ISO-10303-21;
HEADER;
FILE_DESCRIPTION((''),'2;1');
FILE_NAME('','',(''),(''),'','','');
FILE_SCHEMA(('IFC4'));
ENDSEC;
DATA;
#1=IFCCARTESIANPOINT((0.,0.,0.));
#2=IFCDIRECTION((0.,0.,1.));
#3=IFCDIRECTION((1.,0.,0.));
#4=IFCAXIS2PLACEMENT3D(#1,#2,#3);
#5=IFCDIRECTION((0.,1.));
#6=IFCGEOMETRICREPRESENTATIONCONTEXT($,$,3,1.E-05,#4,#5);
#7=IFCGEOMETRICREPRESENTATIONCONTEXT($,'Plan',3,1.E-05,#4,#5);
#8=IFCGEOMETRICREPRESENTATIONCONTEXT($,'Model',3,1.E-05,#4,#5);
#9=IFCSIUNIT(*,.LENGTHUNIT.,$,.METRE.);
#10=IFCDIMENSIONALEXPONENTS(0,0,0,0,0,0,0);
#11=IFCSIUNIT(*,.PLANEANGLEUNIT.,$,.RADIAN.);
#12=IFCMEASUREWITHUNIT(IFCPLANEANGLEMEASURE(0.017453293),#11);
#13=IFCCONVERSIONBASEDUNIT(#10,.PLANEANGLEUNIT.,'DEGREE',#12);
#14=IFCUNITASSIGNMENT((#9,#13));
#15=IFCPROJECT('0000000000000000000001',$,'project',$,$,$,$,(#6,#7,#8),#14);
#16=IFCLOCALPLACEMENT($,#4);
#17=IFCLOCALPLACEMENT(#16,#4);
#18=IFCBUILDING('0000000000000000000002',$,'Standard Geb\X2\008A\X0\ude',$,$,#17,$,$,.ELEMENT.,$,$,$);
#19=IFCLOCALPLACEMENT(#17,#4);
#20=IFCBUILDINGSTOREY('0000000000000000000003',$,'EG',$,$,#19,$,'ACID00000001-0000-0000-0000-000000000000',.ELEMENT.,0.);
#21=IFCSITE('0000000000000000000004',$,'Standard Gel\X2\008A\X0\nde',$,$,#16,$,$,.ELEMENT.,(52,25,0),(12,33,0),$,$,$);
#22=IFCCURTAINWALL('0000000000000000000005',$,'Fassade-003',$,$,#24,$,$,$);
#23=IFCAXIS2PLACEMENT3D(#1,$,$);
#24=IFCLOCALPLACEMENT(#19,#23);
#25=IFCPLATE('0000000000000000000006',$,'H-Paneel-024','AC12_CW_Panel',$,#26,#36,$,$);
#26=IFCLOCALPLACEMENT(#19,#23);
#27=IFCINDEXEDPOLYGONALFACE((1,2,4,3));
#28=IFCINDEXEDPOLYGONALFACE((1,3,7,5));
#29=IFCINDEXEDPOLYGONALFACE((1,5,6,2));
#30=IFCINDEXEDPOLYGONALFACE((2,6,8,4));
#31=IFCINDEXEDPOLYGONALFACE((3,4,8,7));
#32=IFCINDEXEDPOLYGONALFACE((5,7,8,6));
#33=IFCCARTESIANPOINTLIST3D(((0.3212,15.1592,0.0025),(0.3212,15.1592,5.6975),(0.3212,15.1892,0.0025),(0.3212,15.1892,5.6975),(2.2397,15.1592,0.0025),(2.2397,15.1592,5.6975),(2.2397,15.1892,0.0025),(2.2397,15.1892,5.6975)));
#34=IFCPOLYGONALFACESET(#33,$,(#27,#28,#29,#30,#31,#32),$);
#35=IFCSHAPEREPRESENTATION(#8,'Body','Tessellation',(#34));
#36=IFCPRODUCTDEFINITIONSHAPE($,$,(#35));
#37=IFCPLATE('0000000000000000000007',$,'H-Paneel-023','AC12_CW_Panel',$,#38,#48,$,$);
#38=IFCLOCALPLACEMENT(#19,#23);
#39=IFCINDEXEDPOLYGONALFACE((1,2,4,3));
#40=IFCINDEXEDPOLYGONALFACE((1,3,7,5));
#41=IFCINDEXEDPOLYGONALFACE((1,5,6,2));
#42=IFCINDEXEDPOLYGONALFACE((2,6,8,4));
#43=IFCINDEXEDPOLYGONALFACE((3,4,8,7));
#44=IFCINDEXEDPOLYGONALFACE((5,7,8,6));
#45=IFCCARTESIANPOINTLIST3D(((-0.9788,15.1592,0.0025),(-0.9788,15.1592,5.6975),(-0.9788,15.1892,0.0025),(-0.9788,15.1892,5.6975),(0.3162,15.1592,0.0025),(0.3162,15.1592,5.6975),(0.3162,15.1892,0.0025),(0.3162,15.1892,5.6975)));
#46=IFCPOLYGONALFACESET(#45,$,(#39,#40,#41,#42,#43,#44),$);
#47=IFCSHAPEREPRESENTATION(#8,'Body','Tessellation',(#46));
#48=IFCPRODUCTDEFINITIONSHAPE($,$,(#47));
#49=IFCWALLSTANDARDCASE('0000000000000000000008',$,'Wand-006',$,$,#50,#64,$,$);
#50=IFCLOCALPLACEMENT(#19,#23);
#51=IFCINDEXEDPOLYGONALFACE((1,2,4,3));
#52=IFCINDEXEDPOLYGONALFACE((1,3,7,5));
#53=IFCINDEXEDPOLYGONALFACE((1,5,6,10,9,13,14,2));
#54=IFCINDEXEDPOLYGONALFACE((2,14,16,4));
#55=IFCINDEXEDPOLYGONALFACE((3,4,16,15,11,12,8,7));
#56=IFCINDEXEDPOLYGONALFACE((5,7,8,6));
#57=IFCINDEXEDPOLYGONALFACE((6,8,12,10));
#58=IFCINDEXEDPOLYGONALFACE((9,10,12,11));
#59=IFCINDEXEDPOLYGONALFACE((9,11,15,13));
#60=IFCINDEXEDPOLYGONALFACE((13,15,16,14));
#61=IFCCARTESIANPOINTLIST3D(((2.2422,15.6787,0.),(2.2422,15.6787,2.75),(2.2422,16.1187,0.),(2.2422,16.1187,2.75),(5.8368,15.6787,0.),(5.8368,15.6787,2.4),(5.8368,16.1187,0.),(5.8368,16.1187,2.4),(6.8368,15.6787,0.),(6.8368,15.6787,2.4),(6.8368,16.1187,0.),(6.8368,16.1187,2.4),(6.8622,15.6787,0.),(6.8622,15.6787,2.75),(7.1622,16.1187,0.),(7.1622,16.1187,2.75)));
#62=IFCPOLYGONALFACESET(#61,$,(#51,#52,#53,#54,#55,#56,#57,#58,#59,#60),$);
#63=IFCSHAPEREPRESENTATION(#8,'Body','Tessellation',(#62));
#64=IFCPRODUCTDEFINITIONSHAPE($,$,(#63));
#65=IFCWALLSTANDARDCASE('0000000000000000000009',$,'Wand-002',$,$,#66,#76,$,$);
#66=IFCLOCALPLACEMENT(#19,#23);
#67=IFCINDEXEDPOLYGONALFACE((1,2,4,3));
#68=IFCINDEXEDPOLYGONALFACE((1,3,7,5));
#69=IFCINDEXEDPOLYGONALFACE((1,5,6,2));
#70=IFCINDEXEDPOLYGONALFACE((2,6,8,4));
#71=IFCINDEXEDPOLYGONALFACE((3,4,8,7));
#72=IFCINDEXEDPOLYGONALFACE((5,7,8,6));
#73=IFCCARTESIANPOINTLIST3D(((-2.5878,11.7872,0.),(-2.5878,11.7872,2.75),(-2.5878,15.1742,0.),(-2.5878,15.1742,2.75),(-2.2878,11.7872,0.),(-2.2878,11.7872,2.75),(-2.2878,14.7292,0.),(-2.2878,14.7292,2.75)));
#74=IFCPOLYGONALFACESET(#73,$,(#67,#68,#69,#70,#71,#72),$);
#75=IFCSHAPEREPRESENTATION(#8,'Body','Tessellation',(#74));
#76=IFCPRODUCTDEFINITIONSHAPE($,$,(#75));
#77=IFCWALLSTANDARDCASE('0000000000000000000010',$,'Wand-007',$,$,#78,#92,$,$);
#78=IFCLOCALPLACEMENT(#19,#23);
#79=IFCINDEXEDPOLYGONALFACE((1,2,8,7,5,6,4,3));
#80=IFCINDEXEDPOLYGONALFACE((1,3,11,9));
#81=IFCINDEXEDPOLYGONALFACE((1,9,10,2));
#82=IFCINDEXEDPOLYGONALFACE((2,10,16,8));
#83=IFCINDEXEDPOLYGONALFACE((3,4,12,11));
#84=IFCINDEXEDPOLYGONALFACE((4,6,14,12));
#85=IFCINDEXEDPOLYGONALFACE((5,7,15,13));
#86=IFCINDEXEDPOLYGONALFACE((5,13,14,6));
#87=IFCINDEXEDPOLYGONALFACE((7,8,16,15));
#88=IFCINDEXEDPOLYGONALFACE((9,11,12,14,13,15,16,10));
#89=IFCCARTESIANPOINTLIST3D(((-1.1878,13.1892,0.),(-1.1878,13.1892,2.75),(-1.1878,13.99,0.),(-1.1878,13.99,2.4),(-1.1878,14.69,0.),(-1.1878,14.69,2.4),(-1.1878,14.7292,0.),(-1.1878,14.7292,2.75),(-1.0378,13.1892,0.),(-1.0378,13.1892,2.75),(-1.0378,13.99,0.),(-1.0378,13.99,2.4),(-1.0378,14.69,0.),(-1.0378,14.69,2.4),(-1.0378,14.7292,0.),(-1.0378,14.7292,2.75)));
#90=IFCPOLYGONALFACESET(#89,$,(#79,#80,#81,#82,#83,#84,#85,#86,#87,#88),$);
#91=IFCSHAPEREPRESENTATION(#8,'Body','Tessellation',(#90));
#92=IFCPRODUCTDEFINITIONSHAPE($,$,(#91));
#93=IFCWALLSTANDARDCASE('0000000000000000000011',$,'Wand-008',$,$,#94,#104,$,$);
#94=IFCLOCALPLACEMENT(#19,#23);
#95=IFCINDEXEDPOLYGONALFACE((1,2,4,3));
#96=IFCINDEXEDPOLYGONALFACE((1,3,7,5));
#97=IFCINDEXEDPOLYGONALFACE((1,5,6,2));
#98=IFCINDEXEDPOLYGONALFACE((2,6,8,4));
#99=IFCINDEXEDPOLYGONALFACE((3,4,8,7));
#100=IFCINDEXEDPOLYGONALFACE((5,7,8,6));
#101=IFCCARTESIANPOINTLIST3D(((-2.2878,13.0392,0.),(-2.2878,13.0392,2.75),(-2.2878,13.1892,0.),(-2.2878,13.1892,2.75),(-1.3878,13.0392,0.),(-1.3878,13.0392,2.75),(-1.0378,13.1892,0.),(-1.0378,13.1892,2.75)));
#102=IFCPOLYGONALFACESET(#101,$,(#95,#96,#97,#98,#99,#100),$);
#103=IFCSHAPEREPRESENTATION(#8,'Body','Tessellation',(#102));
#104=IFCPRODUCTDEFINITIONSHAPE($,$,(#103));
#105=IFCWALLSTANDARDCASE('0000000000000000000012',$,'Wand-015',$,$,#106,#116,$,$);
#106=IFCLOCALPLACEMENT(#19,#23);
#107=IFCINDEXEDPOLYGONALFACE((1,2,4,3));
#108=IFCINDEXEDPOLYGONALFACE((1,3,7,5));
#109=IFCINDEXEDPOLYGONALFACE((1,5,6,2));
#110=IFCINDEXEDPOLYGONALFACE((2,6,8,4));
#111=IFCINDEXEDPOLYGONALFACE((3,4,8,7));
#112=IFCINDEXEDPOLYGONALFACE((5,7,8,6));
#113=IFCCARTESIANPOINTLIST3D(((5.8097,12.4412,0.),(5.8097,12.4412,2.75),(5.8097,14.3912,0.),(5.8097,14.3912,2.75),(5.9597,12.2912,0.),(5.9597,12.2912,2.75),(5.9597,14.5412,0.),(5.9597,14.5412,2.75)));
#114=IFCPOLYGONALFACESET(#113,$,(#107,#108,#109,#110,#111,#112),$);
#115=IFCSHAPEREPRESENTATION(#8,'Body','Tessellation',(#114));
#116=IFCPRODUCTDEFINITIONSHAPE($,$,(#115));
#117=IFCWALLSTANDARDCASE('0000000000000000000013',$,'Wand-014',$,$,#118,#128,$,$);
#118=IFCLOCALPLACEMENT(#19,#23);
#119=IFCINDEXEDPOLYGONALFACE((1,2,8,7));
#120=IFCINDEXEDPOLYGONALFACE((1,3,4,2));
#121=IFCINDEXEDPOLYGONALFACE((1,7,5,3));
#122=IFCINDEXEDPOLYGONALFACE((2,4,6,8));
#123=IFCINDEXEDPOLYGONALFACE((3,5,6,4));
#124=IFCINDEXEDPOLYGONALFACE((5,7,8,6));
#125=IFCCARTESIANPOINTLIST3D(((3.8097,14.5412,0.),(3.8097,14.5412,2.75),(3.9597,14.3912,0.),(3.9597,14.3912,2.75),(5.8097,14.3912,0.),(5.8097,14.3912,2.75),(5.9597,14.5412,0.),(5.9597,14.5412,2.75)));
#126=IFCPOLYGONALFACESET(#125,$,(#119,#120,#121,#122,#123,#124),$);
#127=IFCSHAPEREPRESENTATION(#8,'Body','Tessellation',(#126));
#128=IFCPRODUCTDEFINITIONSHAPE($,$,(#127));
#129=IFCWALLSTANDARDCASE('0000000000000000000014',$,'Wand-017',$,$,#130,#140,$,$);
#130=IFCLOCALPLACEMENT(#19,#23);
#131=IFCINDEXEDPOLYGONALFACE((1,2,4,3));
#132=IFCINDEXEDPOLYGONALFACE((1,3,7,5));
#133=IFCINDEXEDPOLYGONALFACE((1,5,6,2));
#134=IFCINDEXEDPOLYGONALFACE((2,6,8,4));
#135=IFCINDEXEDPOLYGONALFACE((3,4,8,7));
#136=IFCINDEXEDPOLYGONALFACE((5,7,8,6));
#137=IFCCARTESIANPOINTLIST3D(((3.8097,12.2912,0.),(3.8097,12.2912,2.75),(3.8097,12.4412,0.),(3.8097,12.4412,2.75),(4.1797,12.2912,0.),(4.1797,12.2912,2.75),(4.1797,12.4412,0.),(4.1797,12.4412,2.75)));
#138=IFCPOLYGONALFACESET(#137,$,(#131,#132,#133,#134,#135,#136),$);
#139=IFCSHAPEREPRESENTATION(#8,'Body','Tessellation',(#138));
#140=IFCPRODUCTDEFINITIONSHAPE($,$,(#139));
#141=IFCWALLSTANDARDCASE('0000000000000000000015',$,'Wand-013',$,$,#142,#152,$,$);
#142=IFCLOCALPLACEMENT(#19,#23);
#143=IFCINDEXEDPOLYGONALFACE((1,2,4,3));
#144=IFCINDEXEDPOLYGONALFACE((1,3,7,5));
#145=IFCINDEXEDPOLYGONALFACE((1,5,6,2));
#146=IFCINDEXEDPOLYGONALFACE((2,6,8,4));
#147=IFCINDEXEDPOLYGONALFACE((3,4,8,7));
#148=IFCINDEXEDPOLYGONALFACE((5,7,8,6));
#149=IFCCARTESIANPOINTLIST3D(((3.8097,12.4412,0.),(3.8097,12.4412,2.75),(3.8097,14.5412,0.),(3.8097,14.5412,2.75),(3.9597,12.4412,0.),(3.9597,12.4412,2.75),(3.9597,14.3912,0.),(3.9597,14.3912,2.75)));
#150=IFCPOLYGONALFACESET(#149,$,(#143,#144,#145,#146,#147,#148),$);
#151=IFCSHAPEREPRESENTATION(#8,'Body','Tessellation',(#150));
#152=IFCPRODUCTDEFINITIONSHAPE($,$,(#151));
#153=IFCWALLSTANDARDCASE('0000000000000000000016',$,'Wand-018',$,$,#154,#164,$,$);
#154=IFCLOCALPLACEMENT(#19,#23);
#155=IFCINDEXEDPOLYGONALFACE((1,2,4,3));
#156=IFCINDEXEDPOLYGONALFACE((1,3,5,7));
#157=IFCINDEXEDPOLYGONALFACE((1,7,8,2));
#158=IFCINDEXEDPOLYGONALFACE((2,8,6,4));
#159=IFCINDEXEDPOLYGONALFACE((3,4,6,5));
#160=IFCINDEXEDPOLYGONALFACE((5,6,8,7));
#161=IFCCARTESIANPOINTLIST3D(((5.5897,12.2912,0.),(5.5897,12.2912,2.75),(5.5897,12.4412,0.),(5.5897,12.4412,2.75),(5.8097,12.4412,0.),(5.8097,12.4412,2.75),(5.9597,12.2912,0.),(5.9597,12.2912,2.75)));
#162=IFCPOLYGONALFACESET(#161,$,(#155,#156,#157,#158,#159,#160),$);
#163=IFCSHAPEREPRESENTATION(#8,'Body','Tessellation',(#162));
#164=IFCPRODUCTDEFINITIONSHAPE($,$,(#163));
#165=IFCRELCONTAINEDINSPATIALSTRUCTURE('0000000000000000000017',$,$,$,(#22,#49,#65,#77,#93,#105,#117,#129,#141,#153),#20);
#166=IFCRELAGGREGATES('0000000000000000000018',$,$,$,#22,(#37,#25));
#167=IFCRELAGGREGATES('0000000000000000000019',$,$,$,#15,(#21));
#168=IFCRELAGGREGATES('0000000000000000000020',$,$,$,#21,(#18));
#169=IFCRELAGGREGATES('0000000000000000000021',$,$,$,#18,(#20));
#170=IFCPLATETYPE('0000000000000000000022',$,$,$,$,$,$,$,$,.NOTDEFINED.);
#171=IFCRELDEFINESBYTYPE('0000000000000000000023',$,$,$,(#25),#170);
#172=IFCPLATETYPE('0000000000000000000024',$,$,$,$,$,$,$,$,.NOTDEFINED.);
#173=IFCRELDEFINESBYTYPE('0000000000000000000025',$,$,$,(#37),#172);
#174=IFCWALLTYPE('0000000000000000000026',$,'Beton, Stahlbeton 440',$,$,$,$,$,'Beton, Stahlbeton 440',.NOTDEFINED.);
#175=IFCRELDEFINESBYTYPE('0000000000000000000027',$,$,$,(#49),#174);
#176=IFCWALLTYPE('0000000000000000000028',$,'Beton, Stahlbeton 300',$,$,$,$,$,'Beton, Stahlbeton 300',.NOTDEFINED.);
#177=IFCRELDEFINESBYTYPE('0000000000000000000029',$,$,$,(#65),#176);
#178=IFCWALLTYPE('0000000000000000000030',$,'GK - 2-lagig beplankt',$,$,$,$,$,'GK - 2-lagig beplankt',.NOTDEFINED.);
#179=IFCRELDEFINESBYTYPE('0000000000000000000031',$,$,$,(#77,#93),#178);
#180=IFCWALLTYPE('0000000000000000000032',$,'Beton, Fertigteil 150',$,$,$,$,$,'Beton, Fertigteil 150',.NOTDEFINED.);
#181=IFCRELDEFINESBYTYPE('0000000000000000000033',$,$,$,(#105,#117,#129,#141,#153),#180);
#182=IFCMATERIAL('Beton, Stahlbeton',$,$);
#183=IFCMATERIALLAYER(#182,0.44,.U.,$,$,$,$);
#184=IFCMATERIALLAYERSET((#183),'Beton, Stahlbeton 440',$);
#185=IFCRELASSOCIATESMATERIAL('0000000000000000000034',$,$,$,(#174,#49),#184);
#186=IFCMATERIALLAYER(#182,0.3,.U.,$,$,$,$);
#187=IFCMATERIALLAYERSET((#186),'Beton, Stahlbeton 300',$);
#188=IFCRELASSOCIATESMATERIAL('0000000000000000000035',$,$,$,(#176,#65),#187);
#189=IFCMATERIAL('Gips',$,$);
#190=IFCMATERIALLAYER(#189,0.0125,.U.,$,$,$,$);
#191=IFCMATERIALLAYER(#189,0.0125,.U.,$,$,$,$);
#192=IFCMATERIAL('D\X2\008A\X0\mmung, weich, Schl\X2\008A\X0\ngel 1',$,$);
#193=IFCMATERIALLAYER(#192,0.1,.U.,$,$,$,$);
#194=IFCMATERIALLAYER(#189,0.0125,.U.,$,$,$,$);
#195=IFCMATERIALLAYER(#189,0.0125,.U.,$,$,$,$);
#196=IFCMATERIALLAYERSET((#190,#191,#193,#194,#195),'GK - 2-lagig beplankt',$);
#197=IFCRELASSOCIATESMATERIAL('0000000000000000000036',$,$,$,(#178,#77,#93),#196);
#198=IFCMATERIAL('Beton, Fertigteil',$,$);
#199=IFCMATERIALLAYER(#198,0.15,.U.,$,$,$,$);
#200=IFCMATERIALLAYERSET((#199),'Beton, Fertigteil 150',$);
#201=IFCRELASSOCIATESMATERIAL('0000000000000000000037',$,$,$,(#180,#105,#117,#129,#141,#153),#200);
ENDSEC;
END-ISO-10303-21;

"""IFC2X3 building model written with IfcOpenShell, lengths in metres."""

from ifc_helpers import new_model, entity, si_unit, converted_unit, direction, frame, frame_2d, origin_with_axes, place, context, project, spatial, polyline, rectangle, outline, extrude, source, transform, mapped, material, layer, layer_set, layer_usage, type_object, type_shapes, element, aggregate, save


model = new_model("IFC2X3")

# Units and contexts
model_context = context("Model", 3, precision=1e-05, world=origin_with_axes(), true_north=direction((0.0, 1.0)))
plan_context = context("Plan", 3, precision=1e-05, world=origin_with_axes(), true_north=direction((0.0, 1.0)))
context_of_model = context(None, 3, precision=1e-05, world=origin_with_axes(), true_north=direction((0.0, 1.0)))
ifc_project = project(units=[si_unit("LENGTHUNIT", "METRE"), converted_unit("PLANEANGLEUNIT", "DEGREE", entity("IfcPlaneAngleMeasure", 0.017453293), si_unit("PLANEANGLEUNIT", "RADIAN"), dimensions=[0, 0, 0, 0, 0, 0, 0])], contexts=[context_of_model, plan_context, model_context])

# Site, building, storey
site_placement = place(None, origin_with_axes())
site = spatial("IfcSite", under=ifc_project, at=site_placement, Name="Standard Gel\u008ande", CompositionType="ELEMENT", RefLatitude=(52, 25, 0), RefLongitude=(12, 33, 0))
building_placement = place(site_placement, origin_with_axes())
building = spatial("IfcBuilding", under=site, at=building_placement, Name="Standard Geb\u008aude", CompositionType="ELEMENT")
storey_placement = place(building_placement, origin_with_axes())
storey = spatial("IfcBuildingStorey", under=building, at=storey_placement, Name="EG", LongName="ACID00000001-0000-0000-0000-000000000000", CompositionType="ELEMENT", Elevation=0.0)

# Curtain wall, plates
curtain_wall_placement = place(storey_placement, frame((-0.9813, 15.1742, 0.0), z_axis=(0.0, 0.0, 1.0), x_axis=(1.0, 0.0, 0.0)))
curtain_wall = element("IfcCurtainWall", 1, at=curtain_wall_placement, inside=storey, Name="Fassade-003")
plate_type_1 = type_object("IfcPlateType", PredefinedType="NOTDEFINED")
shared_shape_1 = source(origin_with_axes(), model_context, "Body", "SweptSolid", [
    extrude(outline(polyline([(0.0, 0.0), (0.03, 0.0), (0.03, -1.9185), (0.0, -1.9185), (0.0, 0.0)])), origin_with_axes(), (0.0, 0.0, 1.0), 5.695),
])
type_shapes(plate_type_1, [shared_shape_1])
plate_1_placement = place(storey_placement, frame((0.3212, 15.1592, 0.0025), z_axis=(0.0, 0.0, 1.0), x_axis=(0.0, 1.0, 0.0)))
plate_1 = element("IfcPlate", 2, at=plate_1_placement, type_object=plate_type_1, Name="H-Paneel-024", Description="AC12_CW_Panel", context=model_context, shape_type="MappedRepresentation", body=[
    mapped(shared_shape_1, transform((0.0, 0.0, 0.0), scale=1.0)),
])
plate_type_2 = type_object("IfcPlateType", PredefinedType="NOTDEFINED")
shared_shape_2 = source(origin_with_axes(), model_context, "Body", "SweptSolid", [
    extrude(outline(polyline([(0.0, 0.0), (0.03, 0.0), (0.03, -1.295), (0.0, -1.295), (0.0, 0.0)])), origin_with_axes(), (0.0, 0.0, 1.0), 5.695),
])
type_shapes(plate_type_2, [shared_shape_2])
plate_2_placement = place(storey_placement, frame((-0.9788, 15.1592, 0.0025), z_axis=(0.0, 0.0, 1.0), x_axis=(0.0, 1.0, 0.0)))
plate_2 = element("IfcPlate", 3, at=plate_2_placement, type_object=plate_type_2, Name="H-Paneel-023", Description="AC12_CW_Panel", context=model_context, shape_type="MappedRepresentation", body=[
    mapped(shared_shape_2, transform((0.0, 0.0, 0.0), scale=1.0)),
])

# Wall, opening
ifc_material_1 = material(Name="Beton, Stahlbeton")
ifc_layer_1 = layer(ifc_material_1, 0.44, ventilated="UNKNOWN")
ifc_layer_set_1 = layer_set([ifc_layer_1], Name="Beton, Stahlbeton 440")
ifc_layer_usage_1 = layer_usage(ifc_layer_set_1, "AXIS2", "POSITIVE", 0.0)
wall_type_1 = type_object("IfcWallType", Name="Beton, Stahlbeton 440", ElementType="Beton, Stahlbeton 440", PredefinedType="NOTDEFINED", material=ifc_layer_set_1)
wall_1_placement = place(storey_placement, frame((7.1622, 16.1187, 0.0), z_axis=(0.0, 0.0, 1.0), x_axis=(-1.0, 0.0, 0.0)))
wall_1 = element("IfcWallStandardCase", 4, at=wall_1_placement, inside=storey, type_object=wall_type_1, material=ifc_layer_usage_1, Name="Wand-006", context=model_context, shape_type="SweptSolid", body=[
    extrude(outline(polyline([(0.0, 0.0), (4.92, 0.0), (4.92, 0.44), (0.3, 0.44), (0.0, 0.0)])), origin_with_axes(), (0.0, 0.0, 1.0), 2.75),
])
opening_1_placement = place(wall_1_placement, frame((0.8254, 0.0, 0.0), z_axis=(0.0, 0.0, 1.0), x_axis=(1.0, 0.0, 0.0)))
element("IfcOpeningElement", 5, at=opening_1_placement, inside=storey, cuts=wall_1, ObjectType="Opening", context=model_context, shape_type="SweptSolid", body=[
    extrude(rectangle(XDim=1.0, YDim=2.4, at=frame_2d((0.0, 1.2), x_axis=(-1.0, 0.0))), frame((0.0, 0.0, 0.0), z_axis=(0.0, 1.0, 0.0), x_axis=(-1.0, 0.0, 0.0)), (0.0, 0.0, 1.0), 0.44),
])

# Wall
ifc_layer_2 = layer(ifc_material_1, 0.3, ventilated="UNKNOWN")
ifc_layer_set_2 = layer_set([ifc_layer_2], Name="Beton, Stahlbeton 300")
ifc_layer_usage_2 = layer_usage(ifc_layer_set_2, "AXIS2", "POSITIVE", 0.0)
wall_type_2 = type_object("IfcWallType", Name="Beton, Stahlbeton 300", ElementType="Beton, Stahlbeton 300", PredefinedType="NOTDEFINED", material=ifc_layer_set_2)
wall_2_placement = place(storey_placement, frame((-2.5878, 15.1742, 0.0), z_axis=(0.0, 0.0, 1.0), x_axis=(0.0, -1.0, 0.0)))
element("IfcWallStandardCase", 6, at=wall_2_placement, inside=storey, type_object=wall_type_2, material=ifc_layer_usage_2, Name="Wand-002", context=model_context, shape_type="SweptSolid", body=[
    extrude(outline(polyline([(0.0, 0.0), (3.387, 0.0), (3.387, 0.3), (0.445, 0.3), (0.0, 0.0)])), origin_with_axes(), (0.0, 0.0, 1.0), 2.75),
])

# Wall, opening
ifc_material_2 = material(Name="Gips")
ifc_layer_3 = layer(ifc_material_2, 0.0125, ventilated="UNKNOWN")
ifc_layer_4 = layer(ifc_material_2, 0.0125, ventilated="UNKNOWN")
ifc_material_3 = material(Name="D\u008ammung, weich, Schl\u008angel 1")
ifc_layer_5 = layer(ifc_material_3, 0.1, ventilated="UNKNOWN")
ifc_layer_6 = layer(ifc_material_2, 0.0125, ventilated="UNKNOWN")
ifc_layer_7 = layer(ifc_material_2, 0.0125, ventilated="UNKNOWN")
ifc_layer_set_3 = layer_set([ifc_layer_3, ifc_layer_4, ifc_layer_5, ifc_layer_6, ifc_layer_7], Name="GK - 2-lagig beplankt")
ifc_layer_usage_3 = layer_usage(ifc_layer_set_3, "AXIS2", "POSITIVE", 0.0)
wall_type_3 = type_object("IfcWallType", Name="GK - 2-lagig beplankt", ElementType="GK - 2-lagig beplankt", PredefinedType="NOTDEFINED", material=ifc_layer_set_3)
wall_3_placement = place(storey_placement, frame((-1.0378, 13.1892, 0.0), z_axis=(0.0, 0.0, 1.0), x_axis=(0.0, 1.0, 0.0)))
wall_3 = element("IfcWallStandardCase", 7, at=wall_3_placement, inside=storey, type_object=wall_type_3, material=ifc_layer_usage_3, Name="Wand-007", context=model_context, shape_type="SweptSolid", body=[
    extrude(outline(polyline([(0.0, 0.0), (1.54, 0.0), (1.54, 0.15), (0.0, 0.15), (0.0, 0.0)])), origin_with_axes(), (0.0, 0.0, 1.0), 2.75),
])
opening_2_placement = place(wall_3_placement, frame((1.1508, 0.0, 0.0), z_axis=(0.0, 0.0, 1.0), x_axis=(1.0, 0.0, 0.0)))
element("IfcOpeningElement", 8, at=opening_2_placement, cuts=wall_3, ObjectType="Opening", context=model_context, shape_type="SweptSolid", body=[
    extrude(rectangle(XDim=0.7, YDim=2.4, at=frame_2d((0.0, 1.2), x_axis=(-1.0, 0.0))), frame((0.0, 0.0, 0.0), z_axis=(0.0, 1.0, 0.0), x_axis=(-1.0, 0.0, 0.0)), (0.0, 0.0, 1.0), 0.15),
])

# Walls
ifc_layer_usage_4 = layer_usage(ifc_layer_set_3, "AXIS2", "POSITIVE", 0.0)
wall_4_placement = place(storey_placement, frame((-1.3878, 13.1892, 0.0), z_axis=(0.0, 0.0, 1.0), x_axis=(-1.0, 0.0, 0.0)))
element("IfcWallStandardCase", 9, at=wall_4_placement, inside=storey, type_object=wall_type_3, material=ifc_layer_usage_4, Name="Wand-008", context=model_context, shape_type="SweptSolid", body=[
    extrude(outline(polyline([(-0.35, 0.0), (0.9, 0.0), (0.9, 0.15), (0.0, 0.15), (-0.35, 0.0)])), origin_with_axes(), (0.0, 0.0, 1.0), 2.75),
])
ifc_material_4 = material(Name="Beton, Fertigteil")
ifc_layer_8 = layer(ifc_material_4, 0.15, ventilated="UNKNOWN")
ifc_layer_set_4 = layer_set([ifc_layer_8], Name="Beton, Fertigteil 150")
ifc_layer_usage_5 = layer_usage(ifc_layer_set_4, "AXIS2", "NEGATIVE", 0.0)
wall_type_4 = type_object("IfcWallType", Name="Beton, Fertigteil 150", ElementType="Beton, Fertigteil 150", PredefinedType="NOTDEFINED", material=ifc_layer_set_4)
wall_5_placement = place(storey_placement, frame((5.9597, 14.5412, 0.0), z_axis=(0.0, 0.0, 1.0), x_axis=(0.0, -1.0, 0.0)))
element("IfcWallStandardCase", 10, at=wall_5_placement, inside=storey, type_object=wall_type_4, material=ifc_layer_usage_5, Name="Wand-015", context=model_context, shape_type="SweptSolid", body=[
    extrude(outline(polyline([(0.15, -0.15), (2.1, -0.15), (2.25, 0.0), (0.0, 0.0), (0.15, -0.15)])), origin_with_axes(), (0.0, 0.0, 1.0), 2.75),
])
ifc_layer_usage_6 = layer_usage(ifc_layer_set_4, "AXIS2", "NEGATIVE", 0.0)
wall_6_placement = place(storey_placement, frame((3.9597, 14.5412, 0.0), z_axis=(0.0, 0.0, 1.0), x_axis=(1.0, 0.0, 0.0)))
element("IfcWallStandardCase", 11, at=wall_6_placement, inside=storey, type_object=wall_type_4, material=ifc_layer_usage_6, Name="Wand-014", context=model_context, shape_type="SweptSolid", body=[
    extrude(outline(polyline([(0.0, -0.15), (1.85, -0.15), (2.0, 0.0), (-0.15, 0.0), (0.0, -0.15)])), origin_with_axes(), (0.0, 0.0, 1.0), 2.75),
])
ifc_layer_usage_7 = layer_usage(ifc_layer_set_4, "AXIS2", "POSITIVE", 0.0)
wall_7_placement = place(storey_placement, frame((3.8097, 12.2912, 0.0), z_axis=(0.0, 0.0, 1.0), x_axis=(1.0, 0.0, 0.0)))
element("IfcWallStandardCase", 12, at=wall_7_placement, inside=storey, type_object=wall_type_4, material=ifc_layer_usage_7, Name="Wand-017", context=model_context, shape_type="SweptSolid", body=[
    extrude(outline(polyline([(0.0, 0.0), (0.37, 0.0), (0.37, 0.15), (0.0, 0.15), (0.0, 0.0)])), origin_with_axes(), (0.0, 0.0, 1.0), 2.75),
])
ifc_layer_usage_8 = layer_usage(ifc_layer_set_4, "AXIS2", "NEGATIVE", 0.0)
wall_8_placement = place(storey_placement, frame((3.9597, 14.5412, 0.0), z_axis=(0.0, 0.0, 1.0), x_axis=(0.0, -1.0, 0.0)))
element("IfcWallStandardCase", 13, at=wall_8_placement, inside=storey, type_object=wall_type_4, material=ifc_layer_usage_8, Name="Wand-013", context=model_context, shape_type="SweptSolid", body=[
    extrude(outline(polyline([(0.0, -0.15), (2.1, -0.15), (2.1, 0.0), (0.15, 0.0), (0.0, -0.15)])), origin_with_axes(), (0.0, 0.0, 1.0), 2.75),
])
ifc_layer_usage_9 = layer_usage(ifc_layer_set_4, "AXIS2", "NEGATIVE", 0.0)
wall_9_placement = place(storey_placement, frame((5.9597, 12.2912, 0.0), z_axis=(0.0, 0.0, 1.0), x_axis=(-1.0, 0.0, 0.0)))
element("IfcWallStandardCase", 14, at=wall_9_placement, inside=storey, type_object=wall_type_4, material=ifc_layer_usage_9, Name="Wand-018", context=model_context, shape_type="SweptSolid", body=[
    extrude(outline(polyline([(0.15, -0.15), (0.37, -0.15), (0.37, 0.0), (0.0, 0.0), (0.15, -0.15)])), origin_with_axes(), (0.0, 0.0, 1.0), 2.75),
])

aggregate(curtain_wall, [plate_2, plate_1])

save(model, "model.ifc")
